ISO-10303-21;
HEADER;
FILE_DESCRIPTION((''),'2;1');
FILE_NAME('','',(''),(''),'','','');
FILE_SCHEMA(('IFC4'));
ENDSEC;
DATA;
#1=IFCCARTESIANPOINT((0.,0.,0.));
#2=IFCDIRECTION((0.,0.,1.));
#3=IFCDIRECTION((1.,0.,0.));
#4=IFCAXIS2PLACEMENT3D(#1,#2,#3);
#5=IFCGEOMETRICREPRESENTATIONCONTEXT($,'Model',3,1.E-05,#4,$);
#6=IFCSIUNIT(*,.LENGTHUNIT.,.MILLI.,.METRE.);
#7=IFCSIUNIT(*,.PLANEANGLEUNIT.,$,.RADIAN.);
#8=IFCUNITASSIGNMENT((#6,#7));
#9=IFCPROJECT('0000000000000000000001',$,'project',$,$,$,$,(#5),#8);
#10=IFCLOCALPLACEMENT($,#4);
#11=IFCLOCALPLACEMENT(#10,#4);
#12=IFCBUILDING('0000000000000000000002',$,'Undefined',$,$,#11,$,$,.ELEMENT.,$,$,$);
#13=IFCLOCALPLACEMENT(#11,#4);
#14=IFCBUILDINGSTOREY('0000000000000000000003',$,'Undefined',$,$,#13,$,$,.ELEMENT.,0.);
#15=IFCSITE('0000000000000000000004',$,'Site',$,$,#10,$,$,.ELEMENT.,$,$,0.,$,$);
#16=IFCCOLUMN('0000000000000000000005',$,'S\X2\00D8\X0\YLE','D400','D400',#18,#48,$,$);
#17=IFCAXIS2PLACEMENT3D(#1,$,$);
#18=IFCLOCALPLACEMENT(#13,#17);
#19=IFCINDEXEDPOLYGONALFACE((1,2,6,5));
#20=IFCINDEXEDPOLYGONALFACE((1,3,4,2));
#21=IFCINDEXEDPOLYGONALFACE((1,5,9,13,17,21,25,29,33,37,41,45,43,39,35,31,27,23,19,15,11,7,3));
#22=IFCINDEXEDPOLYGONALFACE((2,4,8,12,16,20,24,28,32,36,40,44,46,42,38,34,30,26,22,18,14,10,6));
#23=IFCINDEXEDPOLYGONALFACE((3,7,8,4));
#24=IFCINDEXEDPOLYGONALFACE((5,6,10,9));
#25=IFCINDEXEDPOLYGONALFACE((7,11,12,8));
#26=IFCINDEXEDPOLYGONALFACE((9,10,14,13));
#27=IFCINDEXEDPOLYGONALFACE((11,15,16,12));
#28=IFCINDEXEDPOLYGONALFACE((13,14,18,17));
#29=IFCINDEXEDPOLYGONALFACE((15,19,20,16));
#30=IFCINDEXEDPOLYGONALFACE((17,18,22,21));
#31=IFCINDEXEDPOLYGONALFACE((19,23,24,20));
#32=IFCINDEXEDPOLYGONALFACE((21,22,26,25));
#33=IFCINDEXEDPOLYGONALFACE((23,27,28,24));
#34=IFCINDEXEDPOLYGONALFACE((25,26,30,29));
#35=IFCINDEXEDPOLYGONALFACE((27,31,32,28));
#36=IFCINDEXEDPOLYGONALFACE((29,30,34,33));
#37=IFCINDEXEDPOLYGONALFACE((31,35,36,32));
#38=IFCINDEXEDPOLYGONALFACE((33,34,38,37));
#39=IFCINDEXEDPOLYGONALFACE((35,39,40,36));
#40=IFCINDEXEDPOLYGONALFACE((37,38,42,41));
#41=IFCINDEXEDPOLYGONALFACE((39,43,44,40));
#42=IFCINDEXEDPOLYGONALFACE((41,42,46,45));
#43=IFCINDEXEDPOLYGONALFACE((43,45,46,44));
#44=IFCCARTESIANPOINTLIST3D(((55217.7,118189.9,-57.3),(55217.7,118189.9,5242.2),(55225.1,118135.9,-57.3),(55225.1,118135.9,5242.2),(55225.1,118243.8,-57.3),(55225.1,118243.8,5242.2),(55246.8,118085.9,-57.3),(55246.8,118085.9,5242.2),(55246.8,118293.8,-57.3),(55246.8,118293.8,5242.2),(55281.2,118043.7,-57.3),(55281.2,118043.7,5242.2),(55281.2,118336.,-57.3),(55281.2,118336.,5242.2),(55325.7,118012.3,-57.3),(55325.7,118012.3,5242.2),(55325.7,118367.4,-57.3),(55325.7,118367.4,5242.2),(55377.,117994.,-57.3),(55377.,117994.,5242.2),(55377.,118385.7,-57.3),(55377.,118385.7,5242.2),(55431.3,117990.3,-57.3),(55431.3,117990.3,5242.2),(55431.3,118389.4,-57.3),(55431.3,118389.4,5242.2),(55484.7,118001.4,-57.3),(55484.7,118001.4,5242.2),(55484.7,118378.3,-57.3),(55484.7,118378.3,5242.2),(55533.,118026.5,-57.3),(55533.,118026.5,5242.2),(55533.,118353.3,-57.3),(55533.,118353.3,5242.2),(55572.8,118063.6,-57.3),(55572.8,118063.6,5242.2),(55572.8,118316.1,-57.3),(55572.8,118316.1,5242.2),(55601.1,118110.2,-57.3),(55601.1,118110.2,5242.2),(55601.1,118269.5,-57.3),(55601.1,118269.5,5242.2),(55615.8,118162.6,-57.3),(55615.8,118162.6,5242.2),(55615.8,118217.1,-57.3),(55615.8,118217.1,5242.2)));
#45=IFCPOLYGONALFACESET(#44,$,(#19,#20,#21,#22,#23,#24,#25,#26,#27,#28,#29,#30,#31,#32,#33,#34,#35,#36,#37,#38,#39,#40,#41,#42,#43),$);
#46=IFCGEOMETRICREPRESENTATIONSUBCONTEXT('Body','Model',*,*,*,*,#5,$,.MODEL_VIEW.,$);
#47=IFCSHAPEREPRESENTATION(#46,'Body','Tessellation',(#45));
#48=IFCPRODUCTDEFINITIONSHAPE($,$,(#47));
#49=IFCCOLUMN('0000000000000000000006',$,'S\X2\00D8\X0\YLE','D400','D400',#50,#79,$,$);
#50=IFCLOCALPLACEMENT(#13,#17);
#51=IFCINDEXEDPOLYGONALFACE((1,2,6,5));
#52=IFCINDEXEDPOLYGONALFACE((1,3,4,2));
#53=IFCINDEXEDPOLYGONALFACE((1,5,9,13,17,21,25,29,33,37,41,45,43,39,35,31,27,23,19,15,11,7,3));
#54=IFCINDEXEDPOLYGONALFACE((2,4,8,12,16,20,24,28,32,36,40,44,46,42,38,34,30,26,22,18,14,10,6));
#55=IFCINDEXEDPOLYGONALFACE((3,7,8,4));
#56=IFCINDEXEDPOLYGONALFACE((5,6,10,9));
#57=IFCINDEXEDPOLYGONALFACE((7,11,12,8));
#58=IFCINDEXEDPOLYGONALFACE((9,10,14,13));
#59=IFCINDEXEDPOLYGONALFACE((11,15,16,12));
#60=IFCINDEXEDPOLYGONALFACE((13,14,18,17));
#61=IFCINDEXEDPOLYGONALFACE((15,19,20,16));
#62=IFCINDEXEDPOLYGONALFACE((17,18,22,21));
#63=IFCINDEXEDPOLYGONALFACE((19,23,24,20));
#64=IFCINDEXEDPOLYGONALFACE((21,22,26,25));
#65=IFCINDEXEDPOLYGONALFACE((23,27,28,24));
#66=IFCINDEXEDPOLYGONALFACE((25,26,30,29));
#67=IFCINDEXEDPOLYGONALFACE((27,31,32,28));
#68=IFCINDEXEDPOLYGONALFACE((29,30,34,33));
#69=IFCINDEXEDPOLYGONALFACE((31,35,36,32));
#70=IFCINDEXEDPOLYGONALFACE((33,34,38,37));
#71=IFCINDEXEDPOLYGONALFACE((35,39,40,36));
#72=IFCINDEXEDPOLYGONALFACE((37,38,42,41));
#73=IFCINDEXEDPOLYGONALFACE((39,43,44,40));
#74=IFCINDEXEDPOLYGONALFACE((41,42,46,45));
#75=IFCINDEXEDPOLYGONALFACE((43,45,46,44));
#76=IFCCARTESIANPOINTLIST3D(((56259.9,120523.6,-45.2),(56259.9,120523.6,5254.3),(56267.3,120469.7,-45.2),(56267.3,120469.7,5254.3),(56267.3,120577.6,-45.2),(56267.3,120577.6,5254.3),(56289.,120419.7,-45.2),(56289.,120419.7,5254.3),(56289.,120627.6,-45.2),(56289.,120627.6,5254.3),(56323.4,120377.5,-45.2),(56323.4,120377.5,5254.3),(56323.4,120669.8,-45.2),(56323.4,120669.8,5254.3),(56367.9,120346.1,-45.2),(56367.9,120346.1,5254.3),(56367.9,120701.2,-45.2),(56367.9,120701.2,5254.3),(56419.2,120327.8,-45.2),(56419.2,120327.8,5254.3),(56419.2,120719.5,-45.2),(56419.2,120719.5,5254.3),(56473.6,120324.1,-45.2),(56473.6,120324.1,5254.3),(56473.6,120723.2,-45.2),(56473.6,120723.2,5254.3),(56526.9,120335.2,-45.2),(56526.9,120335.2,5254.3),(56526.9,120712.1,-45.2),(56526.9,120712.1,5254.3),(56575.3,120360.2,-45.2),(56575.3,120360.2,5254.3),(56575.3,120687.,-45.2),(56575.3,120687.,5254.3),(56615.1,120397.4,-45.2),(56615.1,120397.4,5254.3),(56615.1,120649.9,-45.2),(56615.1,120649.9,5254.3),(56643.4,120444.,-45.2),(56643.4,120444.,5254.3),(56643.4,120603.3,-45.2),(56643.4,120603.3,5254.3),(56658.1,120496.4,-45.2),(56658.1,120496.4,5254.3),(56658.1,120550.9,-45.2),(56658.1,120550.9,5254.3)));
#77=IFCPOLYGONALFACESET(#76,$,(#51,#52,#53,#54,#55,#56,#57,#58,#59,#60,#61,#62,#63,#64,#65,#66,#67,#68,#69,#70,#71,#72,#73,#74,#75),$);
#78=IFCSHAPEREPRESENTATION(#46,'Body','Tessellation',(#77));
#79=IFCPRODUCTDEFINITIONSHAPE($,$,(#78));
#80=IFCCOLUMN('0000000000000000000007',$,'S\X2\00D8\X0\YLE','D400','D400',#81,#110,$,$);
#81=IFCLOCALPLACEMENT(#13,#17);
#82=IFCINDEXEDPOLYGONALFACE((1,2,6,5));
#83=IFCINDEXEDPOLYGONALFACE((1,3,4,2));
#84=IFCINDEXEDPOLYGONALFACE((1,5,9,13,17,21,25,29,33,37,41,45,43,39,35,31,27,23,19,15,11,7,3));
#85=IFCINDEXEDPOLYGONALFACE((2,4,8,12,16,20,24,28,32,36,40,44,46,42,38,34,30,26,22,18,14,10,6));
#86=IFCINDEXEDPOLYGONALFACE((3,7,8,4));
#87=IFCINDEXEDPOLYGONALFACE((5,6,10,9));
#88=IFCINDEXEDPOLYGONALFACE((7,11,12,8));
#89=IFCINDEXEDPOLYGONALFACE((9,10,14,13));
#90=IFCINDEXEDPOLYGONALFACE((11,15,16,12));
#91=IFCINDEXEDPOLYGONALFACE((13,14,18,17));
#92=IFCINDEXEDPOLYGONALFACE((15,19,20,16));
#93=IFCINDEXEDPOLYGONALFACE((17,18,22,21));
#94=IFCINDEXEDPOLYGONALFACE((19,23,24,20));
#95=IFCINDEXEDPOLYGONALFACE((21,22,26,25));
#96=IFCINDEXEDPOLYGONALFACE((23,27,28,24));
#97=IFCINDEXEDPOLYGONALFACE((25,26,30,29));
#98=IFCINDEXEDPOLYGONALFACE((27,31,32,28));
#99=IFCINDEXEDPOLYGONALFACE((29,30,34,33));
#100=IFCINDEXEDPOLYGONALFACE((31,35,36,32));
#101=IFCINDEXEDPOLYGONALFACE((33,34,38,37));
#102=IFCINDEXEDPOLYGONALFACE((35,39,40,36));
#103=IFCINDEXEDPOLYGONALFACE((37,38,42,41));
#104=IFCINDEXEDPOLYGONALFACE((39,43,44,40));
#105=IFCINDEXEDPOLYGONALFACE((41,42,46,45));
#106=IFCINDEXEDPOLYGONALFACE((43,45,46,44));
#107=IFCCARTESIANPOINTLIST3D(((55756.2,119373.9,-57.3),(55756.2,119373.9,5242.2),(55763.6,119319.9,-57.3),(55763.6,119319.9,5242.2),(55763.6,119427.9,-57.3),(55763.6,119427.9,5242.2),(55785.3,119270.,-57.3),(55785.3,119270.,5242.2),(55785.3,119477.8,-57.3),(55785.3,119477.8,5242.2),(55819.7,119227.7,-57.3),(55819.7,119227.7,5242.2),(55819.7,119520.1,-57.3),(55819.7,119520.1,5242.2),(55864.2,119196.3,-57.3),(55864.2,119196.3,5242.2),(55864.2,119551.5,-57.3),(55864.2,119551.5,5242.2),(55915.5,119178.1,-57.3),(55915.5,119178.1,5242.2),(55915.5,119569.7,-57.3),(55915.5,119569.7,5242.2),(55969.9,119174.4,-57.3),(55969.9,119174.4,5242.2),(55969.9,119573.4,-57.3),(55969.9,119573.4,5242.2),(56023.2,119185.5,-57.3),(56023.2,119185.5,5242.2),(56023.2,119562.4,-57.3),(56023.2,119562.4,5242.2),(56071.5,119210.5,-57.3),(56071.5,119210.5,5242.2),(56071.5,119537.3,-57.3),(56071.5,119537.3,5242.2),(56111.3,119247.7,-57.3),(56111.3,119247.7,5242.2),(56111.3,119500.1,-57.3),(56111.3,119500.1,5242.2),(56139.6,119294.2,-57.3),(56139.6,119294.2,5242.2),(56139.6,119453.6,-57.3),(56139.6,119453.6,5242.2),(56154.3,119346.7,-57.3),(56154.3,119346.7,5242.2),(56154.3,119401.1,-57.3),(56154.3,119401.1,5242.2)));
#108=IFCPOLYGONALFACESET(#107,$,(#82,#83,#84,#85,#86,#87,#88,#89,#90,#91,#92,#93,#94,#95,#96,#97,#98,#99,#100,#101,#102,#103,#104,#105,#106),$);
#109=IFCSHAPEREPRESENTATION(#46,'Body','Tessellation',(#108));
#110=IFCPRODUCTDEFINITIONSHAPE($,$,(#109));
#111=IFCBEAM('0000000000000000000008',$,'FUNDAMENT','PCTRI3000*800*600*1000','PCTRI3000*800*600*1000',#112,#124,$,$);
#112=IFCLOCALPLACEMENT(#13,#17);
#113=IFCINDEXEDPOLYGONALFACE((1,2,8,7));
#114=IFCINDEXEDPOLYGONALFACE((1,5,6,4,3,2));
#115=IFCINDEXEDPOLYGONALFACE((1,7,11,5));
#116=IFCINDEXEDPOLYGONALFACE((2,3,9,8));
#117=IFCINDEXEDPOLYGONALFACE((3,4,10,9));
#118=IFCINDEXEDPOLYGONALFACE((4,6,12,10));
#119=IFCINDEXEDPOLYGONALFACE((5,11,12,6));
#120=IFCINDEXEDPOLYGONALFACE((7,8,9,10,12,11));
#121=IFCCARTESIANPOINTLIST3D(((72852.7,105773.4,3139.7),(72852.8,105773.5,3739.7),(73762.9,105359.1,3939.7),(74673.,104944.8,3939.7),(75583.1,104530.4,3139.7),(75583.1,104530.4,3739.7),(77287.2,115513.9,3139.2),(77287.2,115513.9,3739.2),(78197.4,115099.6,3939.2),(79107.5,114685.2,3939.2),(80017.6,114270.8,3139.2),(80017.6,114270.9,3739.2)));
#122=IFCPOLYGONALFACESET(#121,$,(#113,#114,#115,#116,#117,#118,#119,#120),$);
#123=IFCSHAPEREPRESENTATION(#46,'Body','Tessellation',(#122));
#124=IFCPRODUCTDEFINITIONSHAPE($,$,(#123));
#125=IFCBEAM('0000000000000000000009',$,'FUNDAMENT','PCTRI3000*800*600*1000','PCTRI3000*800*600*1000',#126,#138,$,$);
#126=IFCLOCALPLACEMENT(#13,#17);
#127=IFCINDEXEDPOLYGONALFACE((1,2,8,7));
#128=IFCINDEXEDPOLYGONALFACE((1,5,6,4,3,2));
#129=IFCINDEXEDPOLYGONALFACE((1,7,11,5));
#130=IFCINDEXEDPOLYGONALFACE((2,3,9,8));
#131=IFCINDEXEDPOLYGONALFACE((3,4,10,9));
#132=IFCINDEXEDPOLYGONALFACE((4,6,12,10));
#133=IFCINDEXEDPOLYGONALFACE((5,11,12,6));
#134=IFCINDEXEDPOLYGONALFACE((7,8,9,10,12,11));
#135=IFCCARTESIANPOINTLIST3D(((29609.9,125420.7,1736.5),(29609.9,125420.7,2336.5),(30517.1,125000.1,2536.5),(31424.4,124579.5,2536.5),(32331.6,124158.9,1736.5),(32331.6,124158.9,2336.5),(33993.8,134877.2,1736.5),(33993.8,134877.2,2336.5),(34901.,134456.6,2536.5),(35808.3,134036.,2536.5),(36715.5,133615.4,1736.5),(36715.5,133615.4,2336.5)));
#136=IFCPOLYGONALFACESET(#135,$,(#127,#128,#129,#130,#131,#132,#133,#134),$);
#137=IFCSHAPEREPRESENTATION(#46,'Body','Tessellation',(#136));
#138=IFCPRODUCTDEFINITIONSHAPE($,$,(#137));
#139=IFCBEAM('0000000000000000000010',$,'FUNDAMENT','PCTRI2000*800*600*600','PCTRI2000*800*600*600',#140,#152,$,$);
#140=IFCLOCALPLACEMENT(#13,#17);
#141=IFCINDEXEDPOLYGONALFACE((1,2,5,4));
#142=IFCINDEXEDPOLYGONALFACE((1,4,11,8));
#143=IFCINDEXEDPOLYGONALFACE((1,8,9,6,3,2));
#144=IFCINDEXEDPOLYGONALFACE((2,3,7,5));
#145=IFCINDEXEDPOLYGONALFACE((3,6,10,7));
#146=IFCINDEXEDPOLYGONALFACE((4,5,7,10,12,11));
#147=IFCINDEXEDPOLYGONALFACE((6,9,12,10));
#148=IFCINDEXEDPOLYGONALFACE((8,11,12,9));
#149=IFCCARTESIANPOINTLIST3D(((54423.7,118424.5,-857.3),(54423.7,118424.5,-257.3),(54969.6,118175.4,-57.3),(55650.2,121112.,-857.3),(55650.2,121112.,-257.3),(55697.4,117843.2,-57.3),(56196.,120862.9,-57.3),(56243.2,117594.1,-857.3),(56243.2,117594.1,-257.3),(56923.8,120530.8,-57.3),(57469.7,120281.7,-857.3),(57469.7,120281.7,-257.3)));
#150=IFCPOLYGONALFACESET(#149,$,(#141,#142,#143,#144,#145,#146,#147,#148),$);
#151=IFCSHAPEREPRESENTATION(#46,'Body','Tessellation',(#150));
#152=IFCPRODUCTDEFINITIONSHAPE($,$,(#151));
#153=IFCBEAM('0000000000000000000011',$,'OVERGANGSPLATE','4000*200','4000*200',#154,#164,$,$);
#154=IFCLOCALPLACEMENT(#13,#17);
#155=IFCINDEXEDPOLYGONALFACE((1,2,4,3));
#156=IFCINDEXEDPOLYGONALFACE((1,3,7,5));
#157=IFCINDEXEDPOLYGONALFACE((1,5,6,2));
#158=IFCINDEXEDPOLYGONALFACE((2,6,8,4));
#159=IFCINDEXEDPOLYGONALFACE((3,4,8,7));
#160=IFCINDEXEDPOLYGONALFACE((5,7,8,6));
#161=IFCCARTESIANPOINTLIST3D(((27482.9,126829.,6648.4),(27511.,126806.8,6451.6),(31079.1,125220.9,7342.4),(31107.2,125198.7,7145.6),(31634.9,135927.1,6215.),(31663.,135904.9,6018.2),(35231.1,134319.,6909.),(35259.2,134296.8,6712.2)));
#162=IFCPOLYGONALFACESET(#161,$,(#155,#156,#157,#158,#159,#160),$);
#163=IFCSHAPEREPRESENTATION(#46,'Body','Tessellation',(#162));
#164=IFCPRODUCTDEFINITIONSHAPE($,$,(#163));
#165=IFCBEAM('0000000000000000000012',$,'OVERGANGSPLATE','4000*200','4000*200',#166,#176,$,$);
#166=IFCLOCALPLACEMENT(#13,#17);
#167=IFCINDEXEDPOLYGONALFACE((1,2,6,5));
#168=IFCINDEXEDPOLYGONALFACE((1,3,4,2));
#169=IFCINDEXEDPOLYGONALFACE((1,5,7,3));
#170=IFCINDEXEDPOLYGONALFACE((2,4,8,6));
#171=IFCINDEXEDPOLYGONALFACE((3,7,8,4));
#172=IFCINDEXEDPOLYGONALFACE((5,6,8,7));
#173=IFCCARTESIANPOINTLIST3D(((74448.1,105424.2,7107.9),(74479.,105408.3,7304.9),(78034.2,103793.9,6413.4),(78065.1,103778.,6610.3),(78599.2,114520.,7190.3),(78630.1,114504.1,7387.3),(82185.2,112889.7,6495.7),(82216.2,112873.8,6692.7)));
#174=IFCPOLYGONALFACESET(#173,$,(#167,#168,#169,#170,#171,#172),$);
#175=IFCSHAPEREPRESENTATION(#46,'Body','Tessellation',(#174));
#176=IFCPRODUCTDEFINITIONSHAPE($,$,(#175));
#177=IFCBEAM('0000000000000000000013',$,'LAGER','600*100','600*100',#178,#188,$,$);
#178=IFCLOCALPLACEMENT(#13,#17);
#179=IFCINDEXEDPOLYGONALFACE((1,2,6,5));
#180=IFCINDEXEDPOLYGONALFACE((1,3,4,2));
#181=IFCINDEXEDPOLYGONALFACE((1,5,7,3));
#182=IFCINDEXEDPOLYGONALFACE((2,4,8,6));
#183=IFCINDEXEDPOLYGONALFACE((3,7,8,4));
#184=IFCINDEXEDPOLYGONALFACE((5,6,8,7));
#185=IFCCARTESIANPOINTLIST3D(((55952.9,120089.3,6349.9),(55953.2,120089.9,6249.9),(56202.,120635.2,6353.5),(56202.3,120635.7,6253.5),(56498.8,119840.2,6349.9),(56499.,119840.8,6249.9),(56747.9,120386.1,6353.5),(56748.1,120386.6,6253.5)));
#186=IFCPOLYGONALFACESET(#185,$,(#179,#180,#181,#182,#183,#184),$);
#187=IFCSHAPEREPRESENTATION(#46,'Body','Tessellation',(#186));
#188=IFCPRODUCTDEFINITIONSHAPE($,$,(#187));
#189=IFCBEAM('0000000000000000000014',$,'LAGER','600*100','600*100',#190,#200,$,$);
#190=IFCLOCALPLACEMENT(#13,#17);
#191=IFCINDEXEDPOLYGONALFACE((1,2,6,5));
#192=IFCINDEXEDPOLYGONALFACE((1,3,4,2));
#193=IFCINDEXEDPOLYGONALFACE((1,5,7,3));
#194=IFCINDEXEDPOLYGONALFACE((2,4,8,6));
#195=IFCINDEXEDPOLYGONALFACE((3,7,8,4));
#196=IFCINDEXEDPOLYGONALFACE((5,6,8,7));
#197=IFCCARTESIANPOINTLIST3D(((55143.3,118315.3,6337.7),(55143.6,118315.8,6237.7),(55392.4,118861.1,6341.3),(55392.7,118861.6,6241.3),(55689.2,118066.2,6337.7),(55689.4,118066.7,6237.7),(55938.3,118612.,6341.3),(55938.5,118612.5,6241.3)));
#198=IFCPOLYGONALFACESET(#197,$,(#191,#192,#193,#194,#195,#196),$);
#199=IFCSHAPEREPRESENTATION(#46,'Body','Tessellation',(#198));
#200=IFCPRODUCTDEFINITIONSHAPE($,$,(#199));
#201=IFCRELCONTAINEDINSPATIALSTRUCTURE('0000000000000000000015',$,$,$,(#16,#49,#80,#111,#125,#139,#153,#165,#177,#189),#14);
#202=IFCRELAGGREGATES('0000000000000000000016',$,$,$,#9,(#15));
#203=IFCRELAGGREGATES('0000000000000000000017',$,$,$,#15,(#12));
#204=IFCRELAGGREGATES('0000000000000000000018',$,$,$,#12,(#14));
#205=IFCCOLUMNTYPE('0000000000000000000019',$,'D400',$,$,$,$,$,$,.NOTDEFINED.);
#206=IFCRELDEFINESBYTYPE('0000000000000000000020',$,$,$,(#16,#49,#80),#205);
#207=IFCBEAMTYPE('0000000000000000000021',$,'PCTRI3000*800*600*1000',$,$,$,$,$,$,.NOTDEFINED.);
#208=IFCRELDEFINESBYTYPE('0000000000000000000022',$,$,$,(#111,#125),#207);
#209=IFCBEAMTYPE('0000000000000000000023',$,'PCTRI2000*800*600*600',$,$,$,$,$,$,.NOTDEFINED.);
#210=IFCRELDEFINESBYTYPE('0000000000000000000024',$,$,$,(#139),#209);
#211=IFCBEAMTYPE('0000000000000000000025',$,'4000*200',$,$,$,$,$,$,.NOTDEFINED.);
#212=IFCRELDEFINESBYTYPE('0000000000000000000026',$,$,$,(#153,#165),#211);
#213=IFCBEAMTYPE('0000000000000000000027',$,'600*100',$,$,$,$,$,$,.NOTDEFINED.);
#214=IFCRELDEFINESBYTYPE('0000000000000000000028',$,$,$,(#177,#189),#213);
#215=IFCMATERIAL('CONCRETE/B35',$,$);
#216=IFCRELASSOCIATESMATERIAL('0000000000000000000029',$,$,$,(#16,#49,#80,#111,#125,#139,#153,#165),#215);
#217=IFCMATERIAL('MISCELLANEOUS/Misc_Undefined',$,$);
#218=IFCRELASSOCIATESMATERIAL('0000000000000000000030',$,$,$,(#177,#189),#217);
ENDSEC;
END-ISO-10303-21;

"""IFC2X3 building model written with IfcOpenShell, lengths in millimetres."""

from ifc_helpers import new_model, si_unit, frame, origin_with_axes, origin_2d_with_axis, place, context, subcontext, project, spatial, polyline, rectangle, circle, outline, extrude, material, type_object, element, save


model = new_model("IFC2X3")

# Units and contexts
model_context = context("Model", 3, precision=1e-05, world=origin_with_axes())
body_context = subcontext(model_context, "Body", "Model", "MODEL_VIEW")
ifc_project = project(units=[si_unit("LENGTHUNIT", "METRE", prefix="MILLI"), si_unit("PLANEANGLEUNIT", "RADIAN")], contexts=[model_context])

# Site, building, storey
site_placement = place(None, origin_with_axes())
site = spatial("IfcSite", under=ifc_project, at=site_placement, Name="Site", CompositionType="ELEMENT", RefElevation=0.0)
building_placement = place(site_placement, origin_with_axes())
building = spatial("IfcBuilding", under=site, at=building_placement, Name="Undefined", CompositionType="ELEMENT")
storey_placement = place(building_placement, origin_with_axes())
storey = spatial("IfcBuildingStorey", under=building, at=storey_placement, Name="Undefined", CompositionType="ELEMENT", Elevation=0.0)

# Columns
ifc_material_1 = material(Name="CONCRETE/B35")
column_type = type_object("IfcColumnType", Name="D400", PredefinedType="NOTDEFINED")
column_placement = place(storey_placement, frame((55417.7, 118189.9, -57.3), z_axis=(0.0, 0.0, 1.0), x_axis=(0.0, 1.0, 0.0)))
element("IfcColumn", 1, at=column_placement, inside=storey, type_object=column_type, material=ifc_material_1, Name="SØYLE", Description="D400", ObjectType="D400", context=body_context, shape_type="SweptSolid", body=[
    extrude(circle(Radius=200.0, at=origin_2d_with_axis()), frame((0.0, 0.0, 5299.5), z_axis=(0.0, 0.0, -1.0), x_axis=(0.0, 1.0, 0.0)), (0.0, 0.0, 1.0), 5299.5),
])
for number, where, z_axis, x_axis, name in (
    (2, (56459.9, 120523.6, -45.2), (0.0, 0.0, 1.0), (0.0, 1.0, 0.0), "SØYLE"),
    (3, (55956.2, 119373.9, -57.3), (0.0, 0.0, 1.0), (0.0, 1.0, 0.0), "SØYLE"),
):
    element("IfcColumn", number, at=place(storey_placement, frame(where, z_axis=z_axis, x_axis=x_axis)), inside=storey, type_object=column_type, material=ifc_material_1, Name=name, Description="D400", ObjectType="D400", context=body_context, shape_type="SweptSolid", body=[
        extrude(circle(Radius=200.0, at=origin_2d_with_axis()), frame((0.0, 0.0, 5299.5), z_axis=(0.0, 0.0, -1.0), x_axis=(0.0, 1.0, 0.0)), (0.0, 0.0, 1.0), 5299.5),
    ])

# Beams
beam_type_1 = type_object("IfcBeamType", Name="PCTRI3000*800*600*1000", PredefinedType="NOTDEFINED")
beam_1_placement = place(storey_placement, frame((74217.9, 105151.9, 3539.7), z_axis=(0.000019, 0.000042, 1.0), x_axis=(0.414346, 0.91012, -0.000046)))
element("IfcBeam", 4, at=beam_1_placement, inside=storey, type_object=beam_type_1, material=ifc_material_1, Name="FUNDAMENT", Description="PCTRI3000*800*600*1000", ObjectType="PCTRI3000*800*600*1000", context=body_context, shape_type="SweptSolid", body=[
    extrude(outline(polyline([(-500.0, 400.0), (500.0, 400.0), (1500.0, 200.0), (1500.0, -400.0), (-1500.0, -400.0), (-1500.0, 200.0), (-500.0, 400.0)])), frame((10702.4, 0.0, 0.0), z_axis=(-1.0, 0.0, 0.0), x_axis=(0.0, -1.0, 0.0)), (0.0, 0.0, 1.0), 10702.4),
])
beam_2_placement = place(storey_placement, frame((30970.7, 124789.8, 2136.5), z_axis=(-0.000001, -0.000003, 1.0), x_axis=(0.420587, 0.907252, 0.000003)))
element("IfcBeam", 5, at=beam_2_placement, inside=storey, type_object=beam_type_1, material=ifc_material_1, Name="FUNDAMENT", Description="PCTRI3000*800*600*1000", ObjectType="PCTRI3000*800*600*1000", context=body_context, shape_type="SweptSolid", body=[
    extrude(outline(polyline([(-500.0, 400.0), (500.0, 400.0), (1500.0, 200.0), (1500.0, -400.0), (-1500.0, -400.0), (-1500.0, 200.0), (-500.0, 400.0)])), frame((10423.3, 0.0, 0.0), z_axis=(-1.0, 0.0, 0.0), x_axis=(0.0, -1.0, 0.0)), (0.0, 0.0, 1.0), 10423.3),
])
beam_type_2 = type_object("IfcBeamType", Name="PCTRI2000*800*600*600", PredefinedType="NOTDEFINED")
beam_3_placement = place(storey_placement, frame((55333.5, 118009.3, -457.3), z_axis=(0.0, 0.0, 1.0), x_axis=(0.415157, 0.90975, 0.0)))
element("IfcBeam", 6, at=beam_3_placement, inside=storey, type_object=beam_type_2, material=ifc_material_1, Name="FUNDAMENT", Description="PCTRI2000*800*600*600", ObjectType="PCTRI2000*800*600*600", context=body_context, shape_type="SweptSolid", body=[
    extrude(outline(polyline([(-400.0, 400.0), (400.0, 400.0), (1000.0, 200.0), (1000.0, -400.0), (-1000.0, -400.0), (-1000.0, 200.0), (-400.0, 400.0)])), frame((2954.2, 0.0, 0.0), z_axis=(-1.0, 0.0, 0.0), x_axis=(0.0, -1.0, 0.0)), (0.0, 0.0, 1.0), 2954.2),
])
beam_type_3 = type_object("IfcBeamType", Name="4000*200", PredefinedType="NOTDEFINED")
beam_4_placement = place(storey_placement, frame((33447.1, 135111.9, 6463.6), z_axis=(0.899044, -0.402024, 0.173485), x_axis=(-0.414781, -0.908891, 0.043295)))
element("IfcBeam", 7, at=beam_4_placement, inside=storey, type_object=beam_type_3, material=ifc_material_1, Name="OVERGANGSPLATE", Description="4000*200", ObjectType="4000*200", context=body_context, shape_type="SweptSolid", body=[
    extrude(rectangle(XDim=200.0, YDim=4000.0, at=origin_2d_with_axis()), frame((10010.1, 0.0, 0.0), z_axis=(-1.0, 0.0, 0.0), x_axis=(0.0, -1.0, 0.0)), (0.0, 0.0, 1.0), 10010.1),
])
beam_5_placement = place(storey_placement, frame((76256.6, 104601.1, 6859.1), z_axis=(-0.896512, 0.407571, 0.173642), x_axis=(0.415166, 0.909708, 0.008239)))
element("IfcBeam", 8, at=beam_5_placement, inside=storey, type_object=beam_type_3, material=ifc_material_1, Name="OVERGANGSPLATE", Description="4000*200", ObjectType="4000*200", context=body_context, shape_type="SweptSolid", body=[
    extrude(rectangle(XDim=200.0, YDim=4000.0, at=origin_2d_with_axis()), frame((9998.6, 0.0, 0.0), z_axis=(-1.0, 0.0, 0.0), x_axis=(0.0, -1.0, 0.0)), (0.0, 0.0, 1.0), 9998.6),
])
ifc_material_2 = material(Name="MISCELLANEOUS/Misc_Undefined")
beam_type_4 = type_object("IfcBeamType", Name="600*100", PredefinedType="NOTDEFINED")
for number, where, z_axis, x_axis, name in (
    (9, (56226.0, 119965.0, 6299.9), (-0.90975, 0.415157, 0.0), (0.41515, 0.909734, 0.005889), "LAGER"),
    (10, (55416.4, 118191.0, 6287.7), (-0.90975, 0.415157, 0.0), (0.41515, 0.909734, 0.005889), "LAGER"),
):
    element("IfcBeam", number, at=place(storey_placement, frame(where, z_axis=z_axis, x_axis=x_axis)), inside=storey, type_object=beam_type_4, material=ifc_material_2, Name=name, Description="600*100", ObjectType="600*100", context=body_context, shape_type="SweptSolid", body=[
        extrude(rectangle(XDim=100.0, YDim=600.0, at=origin_2d_with_axis()), frame((600.0, 0.0, 0.0), z_axis=(-1.0, 0.0, 0.0), x_axis=(0.0, -1.0, 0.0)), (0.0, 0.0, 1.0), 600.0),
    ])

save(model, "model.ifc")
